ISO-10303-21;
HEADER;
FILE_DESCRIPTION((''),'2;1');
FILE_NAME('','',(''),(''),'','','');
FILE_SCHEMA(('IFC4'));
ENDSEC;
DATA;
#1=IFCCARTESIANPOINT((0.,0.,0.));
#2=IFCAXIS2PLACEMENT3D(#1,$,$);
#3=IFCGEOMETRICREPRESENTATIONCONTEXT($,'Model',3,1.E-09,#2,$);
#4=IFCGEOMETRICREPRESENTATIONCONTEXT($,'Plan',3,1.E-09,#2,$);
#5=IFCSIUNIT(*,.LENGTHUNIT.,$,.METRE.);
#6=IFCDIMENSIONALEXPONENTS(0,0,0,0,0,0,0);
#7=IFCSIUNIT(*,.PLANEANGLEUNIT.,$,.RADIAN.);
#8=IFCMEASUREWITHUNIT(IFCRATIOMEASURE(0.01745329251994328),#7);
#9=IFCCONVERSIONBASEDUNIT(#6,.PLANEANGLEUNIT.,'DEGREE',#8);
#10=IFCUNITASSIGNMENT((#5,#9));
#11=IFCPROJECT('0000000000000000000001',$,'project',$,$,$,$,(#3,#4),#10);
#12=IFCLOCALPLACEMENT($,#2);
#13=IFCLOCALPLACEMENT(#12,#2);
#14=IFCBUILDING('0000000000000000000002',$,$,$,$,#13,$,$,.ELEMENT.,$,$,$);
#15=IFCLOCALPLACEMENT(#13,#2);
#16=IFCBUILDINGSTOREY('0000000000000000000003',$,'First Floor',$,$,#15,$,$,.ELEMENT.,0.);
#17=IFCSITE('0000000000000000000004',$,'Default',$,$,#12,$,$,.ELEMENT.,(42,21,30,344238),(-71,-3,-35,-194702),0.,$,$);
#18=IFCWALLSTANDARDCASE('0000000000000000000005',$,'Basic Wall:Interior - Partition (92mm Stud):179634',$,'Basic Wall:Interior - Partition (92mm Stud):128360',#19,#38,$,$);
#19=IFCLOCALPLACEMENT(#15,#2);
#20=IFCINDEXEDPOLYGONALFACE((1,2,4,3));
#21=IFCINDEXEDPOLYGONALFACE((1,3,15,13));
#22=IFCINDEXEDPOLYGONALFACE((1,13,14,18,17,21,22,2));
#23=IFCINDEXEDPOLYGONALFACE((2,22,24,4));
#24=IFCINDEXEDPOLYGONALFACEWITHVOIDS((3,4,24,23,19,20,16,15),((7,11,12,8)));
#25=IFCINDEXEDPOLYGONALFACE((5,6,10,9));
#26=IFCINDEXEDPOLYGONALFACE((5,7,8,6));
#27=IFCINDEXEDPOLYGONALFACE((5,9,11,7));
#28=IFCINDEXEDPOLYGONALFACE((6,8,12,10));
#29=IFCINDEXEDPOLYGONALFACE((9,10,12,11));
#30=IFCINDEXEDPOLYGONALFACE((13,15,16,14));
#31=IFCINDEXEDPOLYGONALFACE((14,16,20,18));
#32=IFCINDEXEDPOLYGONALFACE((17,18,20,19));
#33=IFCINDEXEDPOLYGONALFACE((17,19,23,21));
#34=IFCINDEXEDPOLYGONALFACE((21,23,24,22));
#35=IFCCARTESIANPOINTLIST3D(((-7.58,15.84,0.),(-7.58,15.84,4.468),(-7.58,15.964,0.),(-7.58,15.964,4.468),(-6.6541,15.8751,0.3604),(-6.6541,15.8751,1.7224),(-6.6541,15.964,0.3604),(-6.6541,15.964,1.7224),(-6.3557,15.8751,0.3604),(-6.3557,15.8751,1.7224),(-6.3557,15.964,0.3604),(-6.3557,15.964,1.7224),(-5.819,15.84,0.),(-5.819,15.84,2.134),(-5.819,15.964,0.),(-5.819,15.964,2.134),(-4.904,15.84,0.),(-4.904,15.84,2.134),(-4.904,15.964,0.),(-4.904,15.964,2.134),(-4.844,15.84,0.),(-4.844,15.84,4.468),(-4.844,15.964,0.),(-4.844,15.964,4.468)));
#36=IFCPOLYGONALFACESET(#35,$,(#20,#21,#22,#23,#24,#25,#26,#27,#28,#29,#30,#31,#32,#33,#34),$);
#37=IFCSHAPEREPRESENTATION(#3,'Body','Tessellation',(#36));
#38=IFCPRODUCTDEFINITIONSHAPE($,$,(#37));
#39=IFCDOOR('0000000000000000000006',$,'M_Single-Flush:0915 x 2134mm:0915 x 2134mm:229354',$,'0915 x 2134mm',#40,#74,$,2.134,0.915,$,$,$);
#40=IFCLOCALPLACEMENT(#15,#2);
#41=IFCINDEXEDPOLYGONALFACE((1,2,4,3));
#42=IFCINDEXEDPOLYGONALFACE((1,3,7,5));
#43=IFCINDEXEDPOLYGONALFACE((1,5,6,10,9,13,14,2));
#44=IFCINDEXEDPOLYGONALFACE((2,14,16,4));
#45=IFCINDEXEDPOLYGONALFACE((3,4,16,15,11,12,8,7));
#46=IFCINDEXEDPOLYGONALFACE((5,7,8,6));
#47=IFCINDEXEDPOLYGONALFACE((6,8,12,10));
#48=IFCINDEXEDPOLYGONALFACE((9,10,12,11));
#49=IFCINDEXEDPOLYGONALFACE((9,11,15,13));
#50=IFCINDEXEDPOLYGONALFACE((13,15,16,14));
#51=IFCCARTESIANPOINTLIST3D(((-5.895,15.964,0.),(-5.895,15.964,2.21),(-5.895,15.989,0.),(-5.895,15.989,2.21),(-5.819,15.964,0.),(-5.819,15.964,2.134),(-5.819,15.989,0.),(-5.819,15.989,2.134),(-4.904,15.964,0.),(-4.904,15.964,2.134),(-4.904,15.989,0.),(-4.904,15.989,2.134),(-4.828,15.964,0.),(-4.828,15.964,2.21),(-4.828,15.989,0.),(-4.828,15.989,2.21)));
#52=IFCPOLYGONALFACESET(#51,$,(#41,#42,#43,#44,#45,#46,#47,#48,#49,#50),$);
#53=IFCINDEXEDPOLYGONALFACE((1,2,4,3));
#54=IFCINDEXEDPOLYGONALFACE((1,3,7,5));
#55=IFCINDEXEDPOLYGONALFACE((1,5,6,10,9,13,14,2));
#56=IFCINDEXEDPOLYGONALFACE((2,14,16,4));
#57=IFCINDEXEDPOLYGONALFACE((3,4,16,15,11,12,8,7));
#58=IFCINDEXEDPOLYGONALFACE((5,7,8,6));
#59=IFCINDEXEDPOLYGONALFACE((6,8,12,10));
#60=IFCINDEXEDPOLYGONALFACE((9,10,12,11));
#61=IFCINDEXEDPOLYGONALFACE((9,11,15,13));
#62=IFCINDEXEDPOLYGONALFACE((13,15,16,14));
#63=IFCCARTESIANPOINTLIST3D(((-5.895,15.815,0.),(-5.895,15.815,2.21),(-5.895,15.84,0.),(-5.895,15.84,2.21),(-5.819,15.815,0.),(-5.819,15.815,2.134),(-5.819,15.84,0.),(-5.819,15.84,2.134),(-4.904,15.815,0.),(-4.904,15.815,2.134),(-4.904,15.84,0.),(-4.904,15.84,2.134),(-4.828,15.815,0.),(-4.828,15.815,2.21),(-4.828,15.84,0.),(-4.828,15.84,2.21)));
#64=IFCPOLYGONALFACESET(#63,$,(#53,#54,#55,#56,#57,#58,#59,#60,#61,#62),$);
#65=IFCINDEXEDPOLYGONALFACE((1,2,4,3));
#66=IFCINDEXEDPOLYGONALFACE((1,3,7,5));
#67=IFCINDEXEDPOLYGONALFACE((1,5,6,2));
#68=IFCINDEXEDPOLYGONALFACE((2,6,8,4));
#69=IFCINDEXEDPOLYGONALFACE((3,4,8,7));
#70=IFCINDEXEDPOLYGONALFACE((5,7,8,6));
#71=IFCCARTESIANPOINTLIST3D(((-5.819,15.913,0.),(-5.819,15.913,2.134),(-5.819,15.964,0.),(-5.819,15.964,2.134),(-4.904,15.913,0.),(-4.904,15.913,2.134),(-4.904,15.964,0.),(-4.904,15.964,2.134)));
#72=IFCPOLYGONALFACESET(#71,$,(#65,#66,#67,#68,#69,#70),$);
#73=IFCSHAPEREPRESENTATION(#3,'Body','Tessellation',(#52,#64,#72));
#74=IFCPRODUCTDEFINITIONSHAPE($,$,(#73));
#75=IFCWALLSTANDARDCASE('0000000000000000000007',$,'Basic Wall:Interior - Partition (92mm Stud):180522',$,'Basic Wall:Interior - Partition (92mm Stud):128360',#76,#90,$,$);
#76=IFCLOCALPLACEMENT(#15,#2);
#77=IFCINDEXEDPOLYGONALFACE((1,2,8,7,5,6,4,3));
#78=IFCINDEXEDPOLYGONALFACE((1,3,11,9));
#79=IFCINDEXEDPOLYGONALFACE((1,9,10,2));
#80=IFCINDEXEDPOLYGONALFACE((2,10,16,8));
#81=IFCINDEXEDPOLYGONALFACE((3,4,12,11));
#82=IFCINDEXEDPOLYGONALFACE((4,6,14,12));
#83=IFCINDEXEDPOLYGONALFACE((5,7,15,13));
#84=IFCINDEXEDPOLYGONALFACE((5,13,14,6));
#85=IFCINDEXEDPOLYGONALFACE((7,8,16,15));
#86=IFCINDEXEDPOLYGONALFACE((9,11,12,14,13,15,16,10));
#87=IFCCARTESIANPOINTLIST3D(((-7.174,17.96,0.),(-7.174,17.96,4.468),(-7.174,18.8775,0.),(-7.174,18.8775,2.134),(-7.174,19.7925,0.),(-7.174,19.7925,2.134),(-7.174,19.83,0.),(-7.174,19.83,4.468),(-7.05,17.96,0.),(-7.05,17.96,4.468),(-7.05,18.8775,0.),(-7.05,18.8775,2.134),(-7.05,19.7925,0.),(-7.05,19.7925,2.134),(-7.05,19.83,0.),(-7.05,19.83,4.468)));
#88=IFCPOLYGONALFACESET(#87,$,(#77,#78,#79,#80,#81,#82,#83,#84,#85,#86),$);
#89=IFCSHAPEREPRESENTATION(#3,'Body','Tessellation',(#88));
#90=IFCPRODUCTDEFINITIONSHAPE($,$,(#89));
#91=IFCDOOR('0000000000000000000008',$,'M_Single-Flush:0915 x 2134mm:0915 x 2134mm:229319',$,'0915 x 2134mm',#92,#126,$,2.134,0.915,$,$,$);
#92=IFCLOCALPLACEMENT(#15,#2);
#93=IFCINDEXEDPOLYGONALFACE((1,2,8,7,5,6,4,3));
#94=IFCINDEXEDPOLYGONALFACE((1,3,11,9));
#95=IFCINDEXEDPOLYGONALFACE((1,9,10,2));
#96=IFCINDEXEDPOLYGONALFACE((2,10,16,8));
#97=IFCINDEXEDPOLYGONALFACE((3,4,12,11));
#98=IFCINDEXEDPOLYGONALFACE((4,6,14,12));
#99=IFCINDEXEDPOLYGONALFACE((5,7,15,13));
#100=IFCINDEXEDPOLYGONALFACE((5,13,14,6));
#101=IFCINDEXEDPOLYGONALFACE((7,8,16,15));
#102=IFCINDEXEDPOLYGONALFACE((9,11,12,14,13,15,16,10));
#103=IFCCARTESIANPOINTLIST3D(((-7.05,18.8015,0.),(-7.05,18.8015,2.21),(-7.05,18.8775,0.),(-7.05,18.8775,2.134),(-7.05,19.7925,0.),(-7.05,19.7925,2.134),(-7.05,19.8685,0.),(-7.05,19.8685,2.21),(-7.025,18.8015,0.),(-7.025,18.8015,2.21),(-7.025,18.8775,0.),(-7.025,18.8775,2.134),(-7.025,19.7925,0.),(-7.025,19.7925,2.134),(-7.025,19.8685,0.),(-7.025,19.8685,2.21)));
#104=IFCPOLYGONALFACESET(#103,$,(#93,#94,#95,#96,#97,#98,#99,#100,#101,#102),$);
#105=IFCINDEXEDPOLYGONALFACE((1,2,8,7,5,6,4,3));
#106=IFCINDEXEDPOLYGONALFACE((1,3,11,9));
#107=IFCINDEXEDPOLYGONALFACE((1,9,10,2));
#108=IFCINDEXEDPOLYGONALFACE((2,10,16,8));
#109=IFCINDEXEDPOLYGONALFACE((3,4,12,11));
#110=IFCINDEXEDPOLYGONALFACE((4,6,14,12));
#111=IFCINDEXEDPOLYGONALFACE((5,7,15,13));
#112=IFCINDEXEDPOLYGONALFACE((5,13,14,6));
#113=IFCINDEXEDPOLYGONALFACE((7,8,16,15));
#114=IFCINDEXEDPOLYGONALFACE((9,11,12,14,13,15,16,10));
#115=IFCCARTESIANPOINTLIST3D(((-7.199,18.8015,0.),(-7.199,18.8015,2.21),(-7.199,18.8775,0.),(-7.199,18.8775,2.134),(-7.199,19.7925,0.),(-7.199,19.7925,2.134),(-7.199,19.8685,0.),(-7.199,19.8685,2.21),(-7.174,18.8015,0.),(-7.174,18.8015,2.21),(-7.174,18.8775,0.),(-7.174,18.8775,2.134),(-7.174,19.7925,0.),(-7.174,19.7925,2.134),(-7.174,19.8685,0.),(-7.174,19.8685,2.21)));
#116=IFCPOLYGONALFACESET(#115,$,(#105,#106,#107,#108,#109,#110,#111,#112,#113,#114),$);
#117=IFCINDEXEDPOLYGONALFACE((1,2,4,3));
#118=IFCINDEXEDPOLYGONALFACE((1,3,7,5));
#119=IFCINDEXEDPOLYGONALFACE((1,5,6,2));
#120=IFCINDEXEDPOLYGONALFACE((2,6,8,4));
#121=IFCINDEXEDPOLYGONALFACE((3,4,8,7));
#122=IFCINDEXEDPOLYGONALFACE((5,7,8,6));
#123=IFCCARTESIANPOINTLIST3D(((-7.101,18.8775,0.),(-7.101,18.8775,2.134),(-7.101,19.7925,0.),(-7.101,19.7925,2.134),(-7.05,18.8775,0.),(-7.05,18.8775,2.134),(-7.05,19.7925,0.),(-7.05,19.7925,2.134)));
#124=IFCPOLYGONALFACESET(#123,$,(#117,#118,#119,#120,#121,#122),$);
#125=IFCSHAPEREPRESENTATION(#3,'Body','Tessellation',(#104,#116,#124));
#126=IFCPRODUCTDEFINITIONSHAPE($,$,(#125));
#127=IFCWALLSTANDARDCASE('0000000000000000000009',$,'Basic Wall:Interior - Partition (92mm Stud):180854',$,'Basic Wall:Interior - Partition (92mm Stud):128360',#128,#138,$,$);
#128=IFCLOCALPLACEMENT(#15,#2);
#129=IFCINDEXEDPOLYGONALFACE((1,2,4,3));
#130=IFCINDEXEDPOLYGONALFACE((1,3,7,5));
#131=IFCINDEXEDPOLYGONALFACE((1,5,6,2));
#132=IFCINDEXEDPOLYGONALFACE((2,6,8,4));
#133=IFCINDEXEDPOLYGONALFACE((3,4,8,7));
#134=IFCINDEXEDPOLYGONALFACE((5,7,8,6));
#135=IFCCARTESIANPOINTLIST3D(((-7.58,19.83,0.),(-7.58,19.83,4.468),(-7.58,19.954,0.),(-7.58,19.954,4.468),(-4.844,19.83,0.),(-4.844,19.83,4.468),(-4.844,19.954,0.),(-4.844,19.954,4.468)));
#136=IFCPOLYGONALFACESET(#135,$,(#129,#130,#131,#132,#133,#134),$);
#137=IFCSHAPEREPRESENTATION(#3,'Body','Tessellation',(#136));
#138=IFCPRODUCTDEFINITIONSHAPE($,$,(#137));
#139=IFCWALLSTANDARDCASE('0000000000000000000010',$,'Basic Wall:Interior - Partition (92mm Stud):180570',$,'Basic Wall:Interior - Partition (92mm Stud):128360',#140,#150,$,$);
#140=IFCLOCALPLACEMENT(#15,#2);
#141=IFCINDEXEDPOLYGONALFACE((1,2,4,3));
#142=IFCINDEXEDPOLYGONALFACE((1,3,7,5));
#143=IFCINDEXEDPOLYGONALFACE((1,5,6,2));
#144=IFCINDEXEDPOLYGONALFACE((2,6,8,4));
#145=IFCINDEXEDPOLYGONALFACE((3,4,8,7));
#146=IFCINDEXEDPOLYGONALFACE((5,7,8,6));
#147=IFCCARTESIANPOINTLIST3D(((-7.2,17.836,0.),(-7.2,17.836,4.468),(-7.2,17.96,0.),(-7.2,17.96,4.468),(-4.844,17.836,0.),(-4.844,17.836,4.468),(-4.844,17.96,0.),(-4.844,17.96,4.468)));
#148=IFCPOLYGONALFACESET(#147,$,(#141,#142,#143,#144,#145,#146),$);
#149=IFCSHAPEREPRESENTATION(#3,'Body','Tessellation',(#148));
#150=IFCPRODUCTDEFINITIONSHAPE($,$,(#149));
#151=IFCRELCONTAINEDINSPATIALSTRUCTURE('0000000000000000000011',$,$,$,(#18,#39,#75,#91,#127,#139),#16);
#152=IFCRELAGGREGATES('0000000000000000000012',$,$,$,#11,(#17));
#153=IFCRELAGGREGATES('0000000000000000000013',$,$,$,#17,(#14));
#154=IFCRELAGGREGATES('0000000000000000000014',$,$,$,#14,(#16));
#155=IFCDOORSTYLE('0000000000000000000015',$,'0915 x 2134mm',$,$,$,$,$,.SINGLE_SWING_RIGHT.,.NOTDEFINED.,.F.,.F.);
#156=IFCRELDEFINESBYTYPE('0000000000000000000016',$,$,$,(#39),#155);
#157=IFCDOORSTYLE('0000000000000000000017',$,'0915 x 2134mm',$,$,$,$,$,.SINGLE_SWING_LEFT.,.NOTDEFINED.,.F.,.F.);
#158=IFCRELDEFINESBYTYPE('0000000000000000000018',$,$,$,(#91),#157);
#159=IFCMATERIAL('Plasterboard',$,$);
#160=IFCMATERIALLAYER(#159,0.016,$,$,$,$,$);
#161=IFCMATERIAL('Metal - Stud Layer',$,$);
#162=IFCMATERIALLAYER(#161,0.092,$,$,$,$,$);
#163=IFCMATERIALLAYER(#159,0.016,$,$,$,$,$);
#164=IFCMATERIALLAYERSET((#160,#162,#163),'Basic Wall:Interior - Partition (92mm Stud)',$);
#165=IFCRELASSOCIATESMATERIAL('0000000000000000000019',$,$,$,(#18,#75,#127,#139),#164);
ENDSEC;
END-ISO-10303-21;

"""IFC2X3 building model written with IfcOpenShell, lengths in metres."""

from ifc_helpers import new_model, entity, si_unit, converted_unit, frame, frame_2d, origin, origin_2d_with_axis, place, context, project, spatial, polyline, rectangle, outline, extrude, source, transform, mapped, material, layer, layer_set, layer_usage, type_object, type_shapes, element, fill, save


model = new_model("IFC2X3")

# Units and contexts
model_context = context("Model", 3, precision=1e-09, world=origin())
plan_context = context("Plan", 3, precision=1e-09, world=origin())
ifc_project = project(units=[si_unit("LENGTHUNIT", "METRE"), converted_unit("PLANEANGLEUNIT", "DEGREE", entity("IfcRatioMeasure", 0.01745329251994328), si_unit("PLANEANGLEUNIT", "RADIAN"), dimensions=[0, 0, 0, 0, 0, 0, 0])], contexts=[model_context, plan_context])

# Site, building, storey
site_placement = place(None, origin())
site = spatial("IfcSite", under=ifc_project, at=site_placement, Name="Default", CompositionType="ELEMENT", RefLatitude=(42, 21, 30, 344238), RefLongitude=(-71, -3, -35, -194702), RefElevation=0.0)
building_placement = place(site_placement, origin())
building = spatial("IfcBuilding", under=site, at=building_placement, CompositionType="ELEMENT")
storey_placement = place(building_placement, origin())
storey = spatial("IfcBuildingStorey", under=building, at=storey_placement, Name="First Floor", CompositionType="ELEMENT", Elevation=0.0)

# Wall, openings, door
ifc_material_1 = material(Name="Plasterboard")
ifc_layer_1 = layer(ifc_material_1, 0.016)
ifc_material_2 = material(Name="Metal - Stud Layer")
ifc_layer_2 = layer(ifc_material_2, 0.092)
ifc_layer_3 = layer(ifc_material_1, 0.016)
ifc_layer_set_1 = layer_set([ifc_layer_1, ifc_layer_2, ifc_layer_3], Name="Basic Wall:Interior - Partition (92mm Stud)")
ifc_layer_usage_1 = layer_usage(ifc_layer_set_1, "AXIS2", "NEGATIVE", 0.062)
wall_1_placement = place(storey_placement, frame((-4.844, 15.902, 0.0), z_axis=(0.0, 0.0, 1.0), x_axis=(-1.0, 0.0, 0.0)))
wall_1 = element("IfcWallStandardCase", 1, at=wall_1_placement, inside=storey, material=ifc_layer_usage_1, Name="Basic Wall:Interior - Partition (92mm Stud):179634", ObjectType="Basic Wall:Interior - Partition (92mm Stud):128360", context=model_context, shape_type="SweptSolid", body=[
    extrude(rectangle(XDim=2.736, YDim=0.124, at=frame_2d((1.368, 0.0), x_axis=(-1.0, 0.0))), origin(), (0.0, 0.0, 1.0), 4.468),
])
opening_1_placement = place(wall_1_placement, origin())
element("IfcOpeningElement", 2, at=opening_1_placement, cuts=wall_1, ObjectType="Opening", context=model_context, shape_type="SweptSolid", body=[
    extrude(rectangle(XDim=1.3621, YDim=0.2985, at=origin_2d_with_axis()), frame((1.6609, -0.1255, 1.0414), z_axis=(0.0, 1.0, 0.0), x_axis=(0.0, 0.0, -1.0)), (0.0, 0.0, 1.0), 0.1524),
])
opening_2_placement = place(wall_1_placement, frame((0.975, 0.062, 0.0)))
opening_2 = element("IfcOpeningElement", 3, at=opening_2_placement, cuts=wall_1, ObjectType="Opening", context=model_context, shape_type="SweptSolid", body=[
    extrude(rectangle(XDim=0.915, YDim=2.134, at=frame_2d((1.067, 0.4575), x_axis=(0.0, 1.0))), frame((0.0, 0.0, 0.0), z_axis=(0.0, -1.0, 0.0), x_axis=(0.0, 0.0, 1.0)), (0.0, 0.0, 1.0), 0.124),
])
door_style_1 = type_object("IfcDoorStyle", Name="0915 x 2134mm", ConstructionType="NOTDEFINED", OperationType="SINGLE_SWING_RIGHT", ParameterTakesPrecedence=False, Sizeable=False)
shared_shape_1 = source(origin(), model_context, "Body", "SweptSolid", [
    extrude(outline(polyline([(-0.5335, -1.124), (0.5335, -1.124), (0.5335, 1.086), (0.4575, 1.086), (0.4575, -1.048), (-0.4575, -1.048), (-0.4575, 1.086), (-0.5335, 1.086), (-0.5335, -1.124)])), frame((0.4575, 0.124, 1.086), z_axis=(0.0, 1.0, 0.0), x_axis=(1.0, 0.0, 0.0)), (0.0, 0.0, 1.0), 0.025),
    extrude(outline(polyline([(-1.124, -0.5335), (1.086, -0.5335), (1.086, -0.4575), (-1.048, -0.4575), (-1.048, 0.4575), (1.086, 0.4575), (1.086, 0.5335), (-1.124, 0.5335), (-1.124, -0.5335)])), frame((0.4575, -0.025, 1.086), z_axis=(0.0, 1.0, 0.0), x_axis=(0.0, 0.0, -1.0)), (0.0, 0.0, 1.0), 0.025),
    extrude(rectangle(XDim=0.051, YDim=0.915, at=origin_2d_with_axis()), frame((0.4575, 0.0985, 0.0), z_axis=(0.0, 0.0, 1.0), x_axis=(0.0, 1.0, 0.0)), (0.0, 0.0, 1.0), 2.134),
])
type_shapes(door_style_1, [shared_shape_1])
door_1_placement = place(opening_2_placement, frame((0.0, 0.0, 0.0), z_axis=(0.0, 0.0, 1.0), x_axis=(-1.0, 0.0, 0.0)))
door_1 = element("IfcDoor", 4, at=door_1_placement, inside=storey, type_object=door_style_1, Name="M_Single-Flush:0915 x 2134mm:0915 x 2134mm:229354", ObjectType="0915 x 2134mm", OverallHeight=2.134, OverallWidth=0.915, context=model_context, shape_type="MappedRepresentation", body=[
    mapped(shared_shape_1, transform((0.0, 0.0, 0.0), scale=1.0)),
])
fill(opening_2, door_1)

# Wall, opening, door
wall_2_placement = place(storey_placement, frame((-7.112, 19.83, 0.0), z_axis=(0.0, 0.0, 1.0), x_axis=(0.0, -1.0, 0.0)))
wall_2 = element("IfcWallStandardCase", 5, at=wall_2_placement, inside=storey, material=ifc_layer_usage_1, Name="Basic Wall:Interior - Partition (92mm Stud):180522", ObjectType="Basic Wall:Interior - Partition (92mm Stud):128360", context=model_context, shape_type="SweptSolid", body=[
    extrude(rectangle(XDim=1.87, YDim=0.124, at=frame_2d((0.935, 0.0), x_axis=(-1.0, 0.0))), origin(), (0.0, 0.0, 1.0), 4.468),
])
opening_3_placement = place(wall_2_placement, frame((0.0375, -0.062, 0.0)))
opening_3 = element("IfcOpeningElement", 6, at=opening_3_placement, cuts=wall_2, ObjectType="Opening", context=model_context, shape_type="SweptSolid", body=[
    extrude(rectangle(XDim=0.915, YDim=2.134, at=frame_2d((1.067, 0.4575), x_axis=(0.0, -1.0))), frame((0.0, 0.0, 0.0), z_axis=(0.0, 1.0, 0.0), x_axis=(0.0, 0.0, 1.0)), (0.0, 0.0, 1.0), 0.124),
])
door_style_2 = type_object("IfcDoorStyle", Name="0915 x 2134mm", ConstructionType="NOTDEFINED", OperationType="SINGLE_SWING_LEFT", ParameterTakesPrecedence=False, Sizeable=False)
shared_shape_2 = source(origin(), model_context, "Body", "SweptSolid", [
    extrude(outline(polyline([(-0.5335, -1.124), (0.5335, -1.124), (0.5335, 1.086), (0.4575, 1.086), (0.4575, -1.048), (-0.4575, -1.048), (-0.4575, 1.086), (-0.5335, 1.086), (-0.5335, -1.124)])), frame((0.4575, 0.149, 1.086), z_axis=(0.0, -1.0, 0.0), x_axis=(-1.0, 0.0, 0.0)), (0.0, 0.0, 1.0), 0.025),
    extrude(outline(polyline([(-1.124, -0.5335), (1.086, -0.5335), (1.086, -0.4575), (-1.048, -0.4575), (-1.048, 0.4575), (1.086, 0.4575), (1.086, 0.5335), (-1.124, 0.5335), (-1.124, -0.5335)])), frame((0.4575, 0.0, 1.086), z_axis=(0.0, -1.0, 0.0), x_axis=(0.0, 0.0, -1.0)), (0.0, 0.0, 1.0), 0.025),
    extrude(rectangle(XDim=0.915, YDim=0.051, at=origin_2d_with_axis()), frame((0.4575, 0.0985, 0.0)), (0.0, 0.0, 1.0), 2.134),
])
type_shapes(door_style_2, [shared_shape_2])
door_2_placement = place(opening_3_placement, origin())
door_2 = element("IfcDoor", 7, at=door_2_placement, inside=storey, type_object=door_style_2, Name="M_Single-Flush:0915 x 2134mm:0915 x 2134mm:229319", ObjectType="0915 x 2134mm", OverallHeight=2.134, OverallWidth=0.915, context=model_context, shape_type="MappedRepresentation", body=[
    mapped(shared_shape_2, transform((0.0, 0.0, 0.0), scale=1.0)),
])
fill(opening_3, door_2)

# Walls
wall_3_placement = place(storey_placement, frame((-4.844, 19.892, 0.0), z_axis=(0.0, 0.0, 1.0), x_axis=(-1.0, 0.0, 0.0)))
element("IfcWallStandardCase", 8, at=wall_3_placement, inside=storey, material=ifc_layer_usage_1, Name="Basic Wall:Interior - Partition (92mm Stud):180854", ObjectType="Basic Wall:Interior - Partition (92mm Stud):128360", context=model_context, shape_type="SweptSolid", body=[
    extrude(rectangle(XDim=2.736, YDim=0.124, at=frame_2d((1.368, 0.0), x_axis=(-1.0, 0.0))), origin(), (0.0, 0.0, 1.0), 4.468),
])
wall_4_placement = place(storey_placement, frame((-7.2, 17.898, 0.0)))
element("IfcWallStandardCase", 9, at=wall_4_placement, inside=storey, material=ifc_layer_usage_1, Name="Basic Wall:Interior - Partition (92mm Stud):180570", ObjectType="Basic Wall:Interior - Partition (92mm Stud):128360", context=model_context, shape_type="SweptSolid", body=[
    extrude(rectangle(XDim=2.356, YDim=0.124, at=frame_2d((1.178, 0.0), x_axis=(-1.0, 0.0))), origin(), (0.0, 0.0, 1.0), 4.468),
])

save(model, "model.ifc")
